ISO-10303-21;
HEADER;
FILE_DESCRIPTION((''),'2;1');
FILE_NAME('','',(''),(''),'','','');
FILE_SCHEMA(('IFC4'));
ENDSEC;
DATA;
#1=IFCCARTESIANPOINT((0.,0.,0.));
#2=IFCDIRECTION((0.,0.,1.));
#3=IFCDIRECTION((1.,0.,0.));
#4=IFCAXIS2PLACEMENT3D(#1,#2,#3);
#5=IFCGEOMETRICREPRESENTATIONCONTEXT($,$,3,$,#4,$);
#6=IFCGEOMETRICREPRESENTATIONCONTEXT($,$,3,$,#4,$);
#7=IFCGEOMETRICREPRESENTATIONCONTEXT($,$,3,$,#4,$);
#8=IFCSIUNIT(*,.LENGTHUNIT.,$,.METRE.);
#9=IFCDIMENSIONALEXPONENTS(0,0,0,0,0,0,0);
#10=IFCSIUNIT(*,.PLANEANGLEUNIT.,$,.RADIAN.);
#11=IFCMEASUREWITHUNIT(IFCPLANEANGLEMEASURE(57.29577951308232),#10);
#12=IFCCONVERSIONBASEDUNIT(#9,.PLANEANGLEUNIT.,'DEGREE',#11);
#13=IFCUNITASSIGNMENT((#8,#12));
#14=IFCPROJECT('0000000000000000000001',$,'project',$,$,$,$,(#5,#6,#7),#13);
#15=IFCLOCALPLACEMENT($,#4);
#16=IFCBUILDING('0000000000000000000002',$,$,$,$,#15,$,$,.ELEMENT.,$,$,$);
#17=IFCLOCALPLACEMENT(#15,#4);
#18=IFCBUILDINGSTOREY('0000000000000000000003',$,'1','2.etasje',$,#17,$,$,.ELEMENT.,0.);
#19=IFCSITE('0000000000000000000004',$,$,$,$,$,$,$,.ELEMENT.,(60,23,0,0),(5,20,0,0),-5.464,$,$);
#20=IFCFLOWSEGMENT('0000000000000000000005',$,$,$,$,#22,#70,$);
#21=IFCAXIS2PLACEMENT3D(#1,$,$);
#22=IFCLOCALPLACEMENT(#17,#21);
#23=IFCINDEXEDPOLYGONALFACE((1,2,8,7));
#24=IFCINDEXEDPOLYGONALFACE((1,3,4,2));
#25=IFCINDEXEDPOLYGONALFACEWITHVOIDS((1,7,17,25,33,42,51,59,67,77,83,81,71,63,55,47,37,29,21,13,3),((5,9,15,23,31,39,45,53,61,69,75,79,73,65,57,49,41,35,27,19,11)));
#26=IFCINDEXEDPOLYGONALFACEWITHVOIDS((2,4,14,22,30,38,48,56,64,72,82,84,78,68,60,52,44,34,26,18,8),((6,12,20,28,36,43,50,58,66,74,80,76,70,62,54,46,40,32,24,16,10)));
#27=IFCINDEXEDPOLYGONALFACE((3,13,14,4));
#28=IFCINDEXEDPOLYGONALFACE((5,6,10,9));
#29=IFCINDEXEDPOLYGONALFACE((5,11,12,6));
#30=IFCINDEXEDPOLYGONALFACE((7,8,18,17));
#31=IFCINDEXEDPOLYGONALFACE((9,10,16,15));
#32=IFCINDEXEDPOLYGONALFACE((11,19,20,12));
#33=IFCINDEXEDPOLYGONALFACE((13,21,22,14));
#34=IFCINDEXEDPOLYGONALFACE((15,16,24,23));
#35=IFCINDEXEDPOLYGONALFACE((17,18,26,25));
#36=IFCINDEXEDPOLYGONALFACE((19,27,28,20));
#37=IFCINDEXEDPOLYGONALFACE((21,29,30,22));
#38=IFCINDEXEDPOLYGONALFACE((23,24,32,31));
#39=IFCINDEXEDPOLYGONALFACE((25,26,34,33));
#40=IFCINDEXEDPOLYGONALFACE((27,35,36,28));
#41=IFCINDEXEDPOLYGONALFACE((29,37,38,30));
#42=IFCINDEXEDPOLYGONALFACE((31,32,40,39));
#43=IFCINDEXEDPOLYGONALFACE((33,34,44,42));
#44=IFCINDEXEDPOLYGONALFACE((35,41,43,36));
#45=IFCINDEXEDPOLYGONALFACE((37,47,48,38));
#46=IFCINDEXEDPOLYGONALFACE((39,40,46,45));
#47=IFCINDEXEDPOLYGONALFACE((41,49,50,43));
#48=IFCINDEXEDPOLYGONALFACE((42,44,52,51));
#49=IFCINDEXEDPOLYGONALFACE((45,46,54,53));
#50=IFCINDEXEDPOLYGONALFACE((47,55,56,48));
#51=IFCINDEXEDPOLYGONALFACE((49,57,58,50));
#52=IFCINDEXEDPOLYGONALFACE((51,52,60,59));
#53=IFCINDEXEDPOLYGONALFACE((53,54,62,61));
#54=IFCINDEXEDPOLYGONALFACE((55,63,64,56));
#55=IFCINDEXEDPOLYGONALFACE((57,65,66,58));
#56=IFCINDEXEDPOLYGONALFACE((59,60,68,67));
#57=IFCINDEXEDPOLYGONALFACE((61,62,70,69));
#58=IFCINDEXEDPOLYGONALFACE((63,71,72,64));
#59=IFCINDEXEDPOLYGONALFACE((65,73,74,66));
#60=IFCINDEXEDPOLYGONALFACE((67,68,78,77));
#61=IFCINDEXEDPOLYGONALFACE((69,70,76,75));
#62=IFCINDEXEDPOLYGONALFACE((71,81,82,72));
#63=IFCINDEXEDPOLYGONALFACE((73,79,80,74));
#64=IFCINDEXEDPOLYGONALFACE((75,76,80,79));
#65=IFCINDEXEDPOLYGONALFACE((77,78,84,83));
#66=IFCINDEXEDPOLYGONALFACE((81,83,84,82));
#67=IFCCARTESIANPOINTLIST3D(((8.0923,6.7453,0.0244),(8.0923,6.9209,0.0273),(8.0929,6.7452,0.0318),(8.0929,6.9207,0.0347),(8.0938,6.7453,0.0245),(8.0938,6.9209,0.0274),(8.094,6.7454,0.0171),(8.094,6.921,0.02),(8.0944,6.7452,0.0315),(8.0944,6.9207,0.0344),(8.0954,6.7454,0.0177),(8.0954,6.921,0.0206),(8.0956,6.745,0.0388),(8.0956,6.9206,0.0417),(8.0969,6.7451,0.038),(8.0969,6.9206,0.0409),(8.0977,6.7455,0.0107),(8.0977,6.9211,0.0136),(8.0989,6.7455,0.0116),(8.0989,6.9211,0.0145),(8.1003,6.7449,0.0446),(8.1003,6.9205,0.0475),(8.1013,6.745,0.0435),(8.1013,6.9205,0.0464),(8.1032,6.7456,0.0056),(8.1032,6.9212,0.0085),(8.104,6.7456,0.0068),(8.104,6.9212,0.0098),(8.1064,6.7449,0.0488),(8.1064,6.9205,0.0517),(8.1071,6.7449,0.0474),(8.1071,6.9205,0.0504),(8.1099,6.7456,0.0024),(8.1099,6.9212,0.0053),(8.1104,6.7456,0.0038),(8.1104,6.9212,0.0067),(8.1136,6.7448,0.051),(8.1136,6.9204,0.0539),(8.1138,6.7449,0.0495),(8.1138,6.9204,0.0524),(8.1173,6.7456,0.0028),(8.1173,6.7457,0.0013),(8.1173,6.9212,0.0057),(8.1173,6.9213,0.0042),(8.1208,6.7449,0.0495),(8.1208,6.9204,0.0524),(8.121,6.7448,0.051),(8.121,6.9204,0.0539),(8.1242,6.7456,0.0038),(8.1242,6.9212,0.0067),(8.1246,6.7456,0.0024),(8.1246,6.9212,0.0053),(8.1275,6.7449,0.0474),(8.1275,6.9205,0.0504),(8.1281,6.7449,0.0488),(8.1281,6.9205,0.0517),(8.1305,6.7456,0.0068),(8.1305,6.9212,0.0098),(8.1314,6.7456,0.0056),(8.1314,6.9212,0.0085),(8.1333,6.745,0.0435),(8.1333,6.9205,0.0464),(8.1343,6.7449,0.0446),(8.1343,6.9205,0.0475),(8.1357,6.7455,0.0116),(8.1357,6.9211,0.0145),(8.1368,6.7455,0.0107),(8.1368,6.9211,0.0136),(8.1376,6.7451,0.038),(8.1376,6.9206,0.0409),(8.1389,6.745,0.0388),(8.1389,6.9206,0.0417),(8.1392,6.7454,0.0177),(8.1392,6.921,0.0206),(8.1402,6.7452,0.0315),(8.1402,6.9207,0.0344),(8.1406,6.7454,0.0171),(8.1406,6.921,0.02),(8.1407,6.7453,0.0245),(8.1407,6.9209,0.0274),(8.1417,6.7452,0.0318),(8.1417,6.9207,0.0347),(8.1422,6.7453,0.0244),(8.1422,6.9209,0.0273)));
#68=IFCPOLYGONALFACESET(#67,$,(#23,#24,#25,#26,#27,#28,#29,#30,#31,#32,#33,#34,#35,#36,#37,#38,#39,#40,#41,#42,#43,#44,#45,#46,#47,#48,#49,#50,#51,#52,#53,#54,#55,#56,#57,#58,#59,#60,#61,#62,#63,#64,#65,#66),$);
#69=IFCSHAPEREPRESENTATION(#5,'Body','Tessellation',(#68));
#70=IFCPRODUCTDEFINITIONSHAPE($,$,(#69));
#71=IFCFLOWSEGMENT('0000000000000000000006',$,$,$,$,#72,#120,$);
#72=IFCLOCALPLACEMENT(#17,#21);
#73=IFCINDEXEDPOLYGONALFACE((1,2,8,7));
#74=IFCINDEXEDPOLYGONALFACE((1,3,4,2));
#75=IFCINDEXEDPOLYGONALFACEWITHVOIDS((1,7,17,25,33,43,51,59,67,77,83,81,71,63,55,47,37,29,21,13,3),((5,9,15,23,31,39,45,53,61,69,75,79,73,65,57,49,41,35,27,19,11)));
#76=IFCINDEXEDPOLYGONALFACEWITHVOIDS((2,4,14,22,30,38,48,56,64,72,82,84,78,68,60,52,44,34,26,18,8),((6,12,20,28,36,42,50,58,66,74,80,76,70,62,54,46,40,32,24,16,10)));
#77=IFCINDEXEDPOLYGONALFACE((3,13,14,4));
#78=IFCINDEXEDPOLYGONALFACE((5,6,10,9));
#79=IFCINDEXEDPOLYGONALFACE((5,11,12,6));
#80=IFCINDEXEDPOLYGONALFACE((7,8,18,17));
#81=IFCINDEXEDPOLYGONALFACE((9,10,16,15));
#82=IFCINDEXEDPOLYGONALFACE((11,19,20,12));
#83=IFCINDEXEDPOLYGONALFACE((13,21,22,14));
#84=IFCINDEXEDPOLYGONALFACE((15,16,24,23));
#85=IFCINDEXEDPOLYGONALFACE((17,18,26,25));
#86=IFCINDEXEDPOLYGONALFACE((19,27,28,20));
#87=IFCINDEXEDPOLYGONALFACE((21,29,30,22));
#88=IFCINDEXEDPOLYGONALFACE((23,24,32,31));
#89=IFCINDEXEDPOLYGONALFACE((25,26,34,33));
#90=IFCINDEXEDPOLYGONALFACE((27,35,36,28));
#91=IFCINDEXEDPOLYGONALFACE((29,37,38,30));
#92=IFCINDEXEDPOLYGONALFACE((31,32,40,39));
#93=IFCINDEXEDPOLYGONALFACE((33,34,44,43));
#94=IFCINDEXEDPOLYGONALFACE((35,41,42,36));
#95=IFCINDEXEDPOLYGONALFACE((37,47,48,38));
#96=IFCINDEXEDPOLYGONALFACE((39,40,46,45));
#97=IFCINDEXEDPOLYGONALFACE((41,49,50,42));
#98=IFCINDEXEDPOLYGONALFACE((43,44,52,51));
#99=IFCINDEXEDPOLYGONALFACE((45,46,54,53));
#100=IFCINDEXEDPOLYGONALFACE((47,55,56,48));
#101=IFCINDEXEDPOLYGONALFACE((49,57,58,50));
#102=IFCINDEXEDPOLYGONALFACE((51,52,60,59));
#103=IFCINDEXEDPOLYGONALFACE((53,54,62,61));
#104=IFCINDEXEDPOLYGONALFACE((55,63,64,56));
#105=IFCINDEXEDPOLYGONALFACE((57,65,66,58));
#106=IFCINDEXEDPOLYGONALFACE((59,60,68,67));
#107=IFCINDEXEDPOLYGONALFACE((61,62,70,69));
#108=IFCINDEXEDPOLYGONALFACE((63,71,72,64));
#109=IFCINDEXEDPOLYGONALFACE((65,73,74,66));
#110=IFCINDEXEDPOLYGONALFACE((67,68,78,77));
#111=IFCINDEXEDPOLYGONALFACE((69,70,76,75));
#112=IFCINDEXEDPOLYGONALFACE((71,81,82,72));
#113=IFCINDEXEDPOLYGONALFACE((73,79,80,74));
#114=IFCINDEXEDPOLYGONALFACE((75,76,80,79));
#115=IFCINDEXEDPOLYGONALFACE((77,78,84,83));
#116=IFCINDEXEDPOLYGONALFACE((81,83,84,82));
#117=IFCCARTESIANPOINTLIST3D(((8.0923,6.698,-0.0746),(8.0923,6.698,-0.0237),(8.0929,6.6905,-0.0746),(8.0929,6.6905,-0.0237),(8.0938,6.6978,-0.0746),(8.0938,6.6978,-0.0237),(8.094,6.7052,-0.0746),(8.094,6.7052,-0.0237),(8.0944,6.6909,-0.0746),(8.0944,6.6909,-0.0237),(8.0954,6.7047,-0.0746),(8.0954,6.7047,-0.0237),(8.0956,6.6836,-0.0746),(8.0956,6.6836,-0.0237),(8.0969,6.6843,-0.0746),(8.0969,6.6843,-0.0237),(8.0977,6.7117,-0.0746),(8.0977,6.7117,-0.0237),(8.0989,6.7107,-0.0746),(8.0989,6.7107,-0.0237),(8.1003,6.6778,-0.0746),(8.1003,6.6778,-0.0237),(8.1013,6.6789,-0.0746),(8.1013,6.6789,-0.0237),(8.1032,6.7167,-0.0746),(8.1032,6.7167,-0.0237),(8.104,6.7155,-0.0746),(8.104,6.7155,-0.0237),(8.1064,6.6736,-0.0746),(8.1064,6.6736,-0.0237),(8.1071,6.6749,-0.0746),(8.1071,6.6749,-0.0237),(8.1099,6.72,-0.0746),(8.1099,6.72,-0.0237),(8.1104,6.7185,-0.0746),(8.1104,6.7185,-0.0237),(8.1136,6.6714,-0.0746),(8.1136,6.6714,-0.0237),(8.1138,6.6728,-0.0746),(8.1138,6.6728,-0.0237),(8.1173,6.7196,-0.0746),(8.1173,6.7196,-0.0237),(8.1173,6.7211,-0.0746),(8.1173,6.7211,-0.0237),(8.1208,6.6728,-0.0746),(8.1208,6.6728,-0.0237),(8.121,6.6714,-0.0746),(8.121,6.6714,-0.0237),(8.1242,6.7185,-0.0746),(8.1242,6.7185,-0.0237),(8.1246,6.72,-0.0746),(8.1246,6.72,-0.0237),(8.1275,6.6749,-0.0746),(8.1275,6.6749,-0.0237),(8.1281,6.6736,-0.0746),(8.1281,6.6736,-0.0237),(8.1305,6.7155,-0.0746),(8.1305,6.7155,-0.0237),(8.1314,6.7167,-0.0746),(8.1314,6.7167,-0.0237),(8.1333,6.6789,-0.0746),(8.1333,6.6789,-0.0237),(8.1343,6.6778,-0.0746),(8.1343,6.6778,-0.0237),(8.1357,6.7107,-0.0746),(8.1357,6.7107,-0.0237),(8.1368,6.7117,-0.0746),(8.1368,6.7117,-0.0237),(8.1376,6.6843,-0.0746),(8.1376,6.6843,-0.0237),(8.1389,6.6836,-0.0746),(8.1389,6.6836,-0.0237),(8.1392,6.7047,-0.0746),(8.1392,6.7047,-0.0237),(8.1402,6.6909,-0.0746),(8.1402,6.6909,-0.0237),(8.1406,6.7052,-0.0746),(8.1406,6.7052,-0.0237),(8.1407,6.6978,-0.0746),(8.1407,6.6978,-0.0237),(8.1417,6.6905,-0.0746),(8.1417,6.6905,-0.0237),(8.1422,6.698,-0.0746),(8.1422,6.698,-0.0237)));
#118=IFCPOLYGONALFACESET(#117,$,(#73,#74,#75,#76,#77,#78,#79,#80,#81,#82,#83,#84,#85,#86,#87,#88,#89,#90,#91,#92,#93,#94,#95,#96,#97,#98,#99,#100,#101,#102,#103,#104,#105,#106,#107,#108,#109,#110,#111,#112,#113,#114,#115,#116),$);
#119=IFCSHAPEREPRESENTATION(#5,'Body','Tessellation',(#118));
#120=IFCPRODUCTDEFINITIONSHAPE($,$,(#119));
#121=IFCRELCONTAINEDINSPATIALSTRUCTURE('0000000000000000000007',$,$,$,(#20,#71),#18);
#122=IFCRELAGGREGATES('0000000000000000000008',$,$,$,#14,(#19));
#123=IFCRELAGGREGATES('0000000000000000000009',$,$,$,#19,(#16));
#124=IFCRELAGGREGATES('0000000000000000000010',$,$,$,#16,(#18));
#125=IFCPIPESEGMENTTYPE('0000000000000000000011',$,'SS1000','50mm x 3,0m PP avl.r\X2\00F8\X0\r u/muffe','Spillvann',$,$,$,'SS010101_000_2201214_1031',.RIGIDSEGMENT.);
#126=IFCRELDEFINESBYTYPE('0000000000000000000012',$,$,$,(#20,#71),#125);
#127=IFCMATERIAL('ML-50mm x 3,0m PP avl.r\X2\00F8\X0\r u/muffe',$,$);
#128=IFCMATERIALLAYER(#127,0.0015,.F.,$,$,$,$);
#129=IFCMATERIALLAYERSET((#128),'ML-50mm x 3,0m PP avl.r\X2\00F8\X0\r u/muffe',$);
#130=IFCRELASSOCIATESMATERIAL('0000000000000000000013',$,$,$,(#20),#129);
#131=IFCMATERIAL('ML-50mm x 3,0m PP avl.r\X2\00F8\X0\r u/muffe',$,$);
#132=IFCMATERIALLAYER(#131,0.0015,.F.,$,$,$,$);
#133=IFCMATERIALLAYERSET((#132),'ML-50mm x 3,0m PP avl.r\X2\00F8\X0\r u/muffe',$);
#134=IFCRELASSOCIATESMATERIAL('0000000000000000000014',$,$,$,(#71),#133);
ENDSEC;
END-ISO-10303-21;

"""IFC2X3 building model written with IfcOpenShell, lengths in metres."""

from ifc_helpers import new_model, entity, si_unit, converted_unit, frame, origin_with_axes, origin_2d_with_axis, place, context, project, spatial, hollow_circle, extrude, material, layer, layer_set, layer_usage, type_object, element, save


model = new_model("IFC2X3")

# Units and contexts
context_of_model_1 = context(None, 3, world=origin_with_axes())
context_of_model_2 = context(None, 3, world=origin_with_axes())
context_of_model_3 = context(None, 3, world=origin_with_axes())
ifc_project = project(units=[si_unit("LENGTHUNIT", "METRE"), converted_unit("PLANEANGLEUNIT", "DEGREE", entity("IfcPlaneAngleMeasure", 57.29577951308232), si_unit("PLANEANGLEUNIT", "RADIAN"), dimensions=[0, 0, 0, 0, 0, 0, 0])], contexts=[context_of_model_1, context_of_model_2, context_of_model_3])

# Site, building, storey
site = spatial("IfcSite", under=ifc_project, CompositionType="ELEMENT", RefLatitude=(60, 23, 0, 0), RefLongitude=(5, 20, 0, 0), RefElevation=-5.464)
building_placement = place(None, origin_with_axes())
building = spatial("IfcBuilding", under=site, at=building_placement, CompositionType="ELEMENT")
storey_placement = place(building_placement, origin_with_axes())
storey = spatial("IfcBuildingStorey", under=building, at=storey_placement, Name="1", Description="2.etasje", CompositionType="ELEMENT", Elevation=0.0)

# Flow segments
pipe_segment_type_1 = type_object("IfcPipeSegmentType", Name="SS1000", Description="50mm x 3,0m PP avl.rør u/muffe", ApplicableOccurrence="Spillvann", ElementType="SS010101_000_2201214_1031", PredefinedType="RIGIDSEGMENT")
ifc_material_1 = material(Name="ML-50mm x 3,0m PP avl.rør u/muffe")
ifc_layer_1 = layer(ifc_material_1, 0.0015, ventilated=False)
ifc_layer_set_1 = layer_set([ifc_layer_1], Name="ML-50mm x 3,0m PP avl.rør u/muffe")
ifc_layer_usage_1 = layer_usage(ifc_layer_set_1, "AXIS2", "POSITIVE", 0.0)
flow_segment_1_placement = place(storey_placement, frame((8.1173, 6.9208, 0.0292), z_axis=(0.0, -0.999861, -0.016665), x_axis=(0.0, 0.016665, -0.999861)))
element("IfcFlowSegment", 1, at=flow_segment_1_placement, inside=storey, type_object=pipe_segment_type_1, material=ifc_layer_usage_1, context=context_of_model_1, shape_type="SweptSolid", body=[
    extrude(hollow_circle(Radius=0.025, WallThickness=0.0015, at=origin_2d_with_axis()), origin_with_axes(), (0.0, 0.0, 1.0), 0.1756),
])
ifc_material_2 = material(Name="ML-50mm x 3,0m PP avl.rør u/muffe")
ifc_layer_2 = layer(ifc_material_2, 0.0015, ventilated=False)
ifc_layer_set_2 = layer_set([ifc_layer_2], Name="ML-50mm x 3,0m PP avl.rør u/muffe")
ifc_layer_usage_2 = layer_usage(ifc_layer_set_2, "AXIS2", "POSITIVE", 0.0)
flow_segment_2_placement = place(storey_placement, frame((8.1173, 6.6961, -0.0237), z_axis=(0.0, 0.0, -1.0), x_axis=(0.0, 1.0, 0.0)))
element("IfcFlowSegment", 2, at=flow_segment_2_placement, inside=storey, type_object=pipe_segment_type_1, material=ifc_layer_usage_2, context=context_of_model_1, shape_type="SweptSolid", body=[
    extrude(hollow_circle(Radius=0.025, WallThickness=0.0015, at=origin_2d_with_axis()), origin_with_axes(), (0.0, 0.0, 1.0), 0.0509),
])

save(model, "model.ifc")
